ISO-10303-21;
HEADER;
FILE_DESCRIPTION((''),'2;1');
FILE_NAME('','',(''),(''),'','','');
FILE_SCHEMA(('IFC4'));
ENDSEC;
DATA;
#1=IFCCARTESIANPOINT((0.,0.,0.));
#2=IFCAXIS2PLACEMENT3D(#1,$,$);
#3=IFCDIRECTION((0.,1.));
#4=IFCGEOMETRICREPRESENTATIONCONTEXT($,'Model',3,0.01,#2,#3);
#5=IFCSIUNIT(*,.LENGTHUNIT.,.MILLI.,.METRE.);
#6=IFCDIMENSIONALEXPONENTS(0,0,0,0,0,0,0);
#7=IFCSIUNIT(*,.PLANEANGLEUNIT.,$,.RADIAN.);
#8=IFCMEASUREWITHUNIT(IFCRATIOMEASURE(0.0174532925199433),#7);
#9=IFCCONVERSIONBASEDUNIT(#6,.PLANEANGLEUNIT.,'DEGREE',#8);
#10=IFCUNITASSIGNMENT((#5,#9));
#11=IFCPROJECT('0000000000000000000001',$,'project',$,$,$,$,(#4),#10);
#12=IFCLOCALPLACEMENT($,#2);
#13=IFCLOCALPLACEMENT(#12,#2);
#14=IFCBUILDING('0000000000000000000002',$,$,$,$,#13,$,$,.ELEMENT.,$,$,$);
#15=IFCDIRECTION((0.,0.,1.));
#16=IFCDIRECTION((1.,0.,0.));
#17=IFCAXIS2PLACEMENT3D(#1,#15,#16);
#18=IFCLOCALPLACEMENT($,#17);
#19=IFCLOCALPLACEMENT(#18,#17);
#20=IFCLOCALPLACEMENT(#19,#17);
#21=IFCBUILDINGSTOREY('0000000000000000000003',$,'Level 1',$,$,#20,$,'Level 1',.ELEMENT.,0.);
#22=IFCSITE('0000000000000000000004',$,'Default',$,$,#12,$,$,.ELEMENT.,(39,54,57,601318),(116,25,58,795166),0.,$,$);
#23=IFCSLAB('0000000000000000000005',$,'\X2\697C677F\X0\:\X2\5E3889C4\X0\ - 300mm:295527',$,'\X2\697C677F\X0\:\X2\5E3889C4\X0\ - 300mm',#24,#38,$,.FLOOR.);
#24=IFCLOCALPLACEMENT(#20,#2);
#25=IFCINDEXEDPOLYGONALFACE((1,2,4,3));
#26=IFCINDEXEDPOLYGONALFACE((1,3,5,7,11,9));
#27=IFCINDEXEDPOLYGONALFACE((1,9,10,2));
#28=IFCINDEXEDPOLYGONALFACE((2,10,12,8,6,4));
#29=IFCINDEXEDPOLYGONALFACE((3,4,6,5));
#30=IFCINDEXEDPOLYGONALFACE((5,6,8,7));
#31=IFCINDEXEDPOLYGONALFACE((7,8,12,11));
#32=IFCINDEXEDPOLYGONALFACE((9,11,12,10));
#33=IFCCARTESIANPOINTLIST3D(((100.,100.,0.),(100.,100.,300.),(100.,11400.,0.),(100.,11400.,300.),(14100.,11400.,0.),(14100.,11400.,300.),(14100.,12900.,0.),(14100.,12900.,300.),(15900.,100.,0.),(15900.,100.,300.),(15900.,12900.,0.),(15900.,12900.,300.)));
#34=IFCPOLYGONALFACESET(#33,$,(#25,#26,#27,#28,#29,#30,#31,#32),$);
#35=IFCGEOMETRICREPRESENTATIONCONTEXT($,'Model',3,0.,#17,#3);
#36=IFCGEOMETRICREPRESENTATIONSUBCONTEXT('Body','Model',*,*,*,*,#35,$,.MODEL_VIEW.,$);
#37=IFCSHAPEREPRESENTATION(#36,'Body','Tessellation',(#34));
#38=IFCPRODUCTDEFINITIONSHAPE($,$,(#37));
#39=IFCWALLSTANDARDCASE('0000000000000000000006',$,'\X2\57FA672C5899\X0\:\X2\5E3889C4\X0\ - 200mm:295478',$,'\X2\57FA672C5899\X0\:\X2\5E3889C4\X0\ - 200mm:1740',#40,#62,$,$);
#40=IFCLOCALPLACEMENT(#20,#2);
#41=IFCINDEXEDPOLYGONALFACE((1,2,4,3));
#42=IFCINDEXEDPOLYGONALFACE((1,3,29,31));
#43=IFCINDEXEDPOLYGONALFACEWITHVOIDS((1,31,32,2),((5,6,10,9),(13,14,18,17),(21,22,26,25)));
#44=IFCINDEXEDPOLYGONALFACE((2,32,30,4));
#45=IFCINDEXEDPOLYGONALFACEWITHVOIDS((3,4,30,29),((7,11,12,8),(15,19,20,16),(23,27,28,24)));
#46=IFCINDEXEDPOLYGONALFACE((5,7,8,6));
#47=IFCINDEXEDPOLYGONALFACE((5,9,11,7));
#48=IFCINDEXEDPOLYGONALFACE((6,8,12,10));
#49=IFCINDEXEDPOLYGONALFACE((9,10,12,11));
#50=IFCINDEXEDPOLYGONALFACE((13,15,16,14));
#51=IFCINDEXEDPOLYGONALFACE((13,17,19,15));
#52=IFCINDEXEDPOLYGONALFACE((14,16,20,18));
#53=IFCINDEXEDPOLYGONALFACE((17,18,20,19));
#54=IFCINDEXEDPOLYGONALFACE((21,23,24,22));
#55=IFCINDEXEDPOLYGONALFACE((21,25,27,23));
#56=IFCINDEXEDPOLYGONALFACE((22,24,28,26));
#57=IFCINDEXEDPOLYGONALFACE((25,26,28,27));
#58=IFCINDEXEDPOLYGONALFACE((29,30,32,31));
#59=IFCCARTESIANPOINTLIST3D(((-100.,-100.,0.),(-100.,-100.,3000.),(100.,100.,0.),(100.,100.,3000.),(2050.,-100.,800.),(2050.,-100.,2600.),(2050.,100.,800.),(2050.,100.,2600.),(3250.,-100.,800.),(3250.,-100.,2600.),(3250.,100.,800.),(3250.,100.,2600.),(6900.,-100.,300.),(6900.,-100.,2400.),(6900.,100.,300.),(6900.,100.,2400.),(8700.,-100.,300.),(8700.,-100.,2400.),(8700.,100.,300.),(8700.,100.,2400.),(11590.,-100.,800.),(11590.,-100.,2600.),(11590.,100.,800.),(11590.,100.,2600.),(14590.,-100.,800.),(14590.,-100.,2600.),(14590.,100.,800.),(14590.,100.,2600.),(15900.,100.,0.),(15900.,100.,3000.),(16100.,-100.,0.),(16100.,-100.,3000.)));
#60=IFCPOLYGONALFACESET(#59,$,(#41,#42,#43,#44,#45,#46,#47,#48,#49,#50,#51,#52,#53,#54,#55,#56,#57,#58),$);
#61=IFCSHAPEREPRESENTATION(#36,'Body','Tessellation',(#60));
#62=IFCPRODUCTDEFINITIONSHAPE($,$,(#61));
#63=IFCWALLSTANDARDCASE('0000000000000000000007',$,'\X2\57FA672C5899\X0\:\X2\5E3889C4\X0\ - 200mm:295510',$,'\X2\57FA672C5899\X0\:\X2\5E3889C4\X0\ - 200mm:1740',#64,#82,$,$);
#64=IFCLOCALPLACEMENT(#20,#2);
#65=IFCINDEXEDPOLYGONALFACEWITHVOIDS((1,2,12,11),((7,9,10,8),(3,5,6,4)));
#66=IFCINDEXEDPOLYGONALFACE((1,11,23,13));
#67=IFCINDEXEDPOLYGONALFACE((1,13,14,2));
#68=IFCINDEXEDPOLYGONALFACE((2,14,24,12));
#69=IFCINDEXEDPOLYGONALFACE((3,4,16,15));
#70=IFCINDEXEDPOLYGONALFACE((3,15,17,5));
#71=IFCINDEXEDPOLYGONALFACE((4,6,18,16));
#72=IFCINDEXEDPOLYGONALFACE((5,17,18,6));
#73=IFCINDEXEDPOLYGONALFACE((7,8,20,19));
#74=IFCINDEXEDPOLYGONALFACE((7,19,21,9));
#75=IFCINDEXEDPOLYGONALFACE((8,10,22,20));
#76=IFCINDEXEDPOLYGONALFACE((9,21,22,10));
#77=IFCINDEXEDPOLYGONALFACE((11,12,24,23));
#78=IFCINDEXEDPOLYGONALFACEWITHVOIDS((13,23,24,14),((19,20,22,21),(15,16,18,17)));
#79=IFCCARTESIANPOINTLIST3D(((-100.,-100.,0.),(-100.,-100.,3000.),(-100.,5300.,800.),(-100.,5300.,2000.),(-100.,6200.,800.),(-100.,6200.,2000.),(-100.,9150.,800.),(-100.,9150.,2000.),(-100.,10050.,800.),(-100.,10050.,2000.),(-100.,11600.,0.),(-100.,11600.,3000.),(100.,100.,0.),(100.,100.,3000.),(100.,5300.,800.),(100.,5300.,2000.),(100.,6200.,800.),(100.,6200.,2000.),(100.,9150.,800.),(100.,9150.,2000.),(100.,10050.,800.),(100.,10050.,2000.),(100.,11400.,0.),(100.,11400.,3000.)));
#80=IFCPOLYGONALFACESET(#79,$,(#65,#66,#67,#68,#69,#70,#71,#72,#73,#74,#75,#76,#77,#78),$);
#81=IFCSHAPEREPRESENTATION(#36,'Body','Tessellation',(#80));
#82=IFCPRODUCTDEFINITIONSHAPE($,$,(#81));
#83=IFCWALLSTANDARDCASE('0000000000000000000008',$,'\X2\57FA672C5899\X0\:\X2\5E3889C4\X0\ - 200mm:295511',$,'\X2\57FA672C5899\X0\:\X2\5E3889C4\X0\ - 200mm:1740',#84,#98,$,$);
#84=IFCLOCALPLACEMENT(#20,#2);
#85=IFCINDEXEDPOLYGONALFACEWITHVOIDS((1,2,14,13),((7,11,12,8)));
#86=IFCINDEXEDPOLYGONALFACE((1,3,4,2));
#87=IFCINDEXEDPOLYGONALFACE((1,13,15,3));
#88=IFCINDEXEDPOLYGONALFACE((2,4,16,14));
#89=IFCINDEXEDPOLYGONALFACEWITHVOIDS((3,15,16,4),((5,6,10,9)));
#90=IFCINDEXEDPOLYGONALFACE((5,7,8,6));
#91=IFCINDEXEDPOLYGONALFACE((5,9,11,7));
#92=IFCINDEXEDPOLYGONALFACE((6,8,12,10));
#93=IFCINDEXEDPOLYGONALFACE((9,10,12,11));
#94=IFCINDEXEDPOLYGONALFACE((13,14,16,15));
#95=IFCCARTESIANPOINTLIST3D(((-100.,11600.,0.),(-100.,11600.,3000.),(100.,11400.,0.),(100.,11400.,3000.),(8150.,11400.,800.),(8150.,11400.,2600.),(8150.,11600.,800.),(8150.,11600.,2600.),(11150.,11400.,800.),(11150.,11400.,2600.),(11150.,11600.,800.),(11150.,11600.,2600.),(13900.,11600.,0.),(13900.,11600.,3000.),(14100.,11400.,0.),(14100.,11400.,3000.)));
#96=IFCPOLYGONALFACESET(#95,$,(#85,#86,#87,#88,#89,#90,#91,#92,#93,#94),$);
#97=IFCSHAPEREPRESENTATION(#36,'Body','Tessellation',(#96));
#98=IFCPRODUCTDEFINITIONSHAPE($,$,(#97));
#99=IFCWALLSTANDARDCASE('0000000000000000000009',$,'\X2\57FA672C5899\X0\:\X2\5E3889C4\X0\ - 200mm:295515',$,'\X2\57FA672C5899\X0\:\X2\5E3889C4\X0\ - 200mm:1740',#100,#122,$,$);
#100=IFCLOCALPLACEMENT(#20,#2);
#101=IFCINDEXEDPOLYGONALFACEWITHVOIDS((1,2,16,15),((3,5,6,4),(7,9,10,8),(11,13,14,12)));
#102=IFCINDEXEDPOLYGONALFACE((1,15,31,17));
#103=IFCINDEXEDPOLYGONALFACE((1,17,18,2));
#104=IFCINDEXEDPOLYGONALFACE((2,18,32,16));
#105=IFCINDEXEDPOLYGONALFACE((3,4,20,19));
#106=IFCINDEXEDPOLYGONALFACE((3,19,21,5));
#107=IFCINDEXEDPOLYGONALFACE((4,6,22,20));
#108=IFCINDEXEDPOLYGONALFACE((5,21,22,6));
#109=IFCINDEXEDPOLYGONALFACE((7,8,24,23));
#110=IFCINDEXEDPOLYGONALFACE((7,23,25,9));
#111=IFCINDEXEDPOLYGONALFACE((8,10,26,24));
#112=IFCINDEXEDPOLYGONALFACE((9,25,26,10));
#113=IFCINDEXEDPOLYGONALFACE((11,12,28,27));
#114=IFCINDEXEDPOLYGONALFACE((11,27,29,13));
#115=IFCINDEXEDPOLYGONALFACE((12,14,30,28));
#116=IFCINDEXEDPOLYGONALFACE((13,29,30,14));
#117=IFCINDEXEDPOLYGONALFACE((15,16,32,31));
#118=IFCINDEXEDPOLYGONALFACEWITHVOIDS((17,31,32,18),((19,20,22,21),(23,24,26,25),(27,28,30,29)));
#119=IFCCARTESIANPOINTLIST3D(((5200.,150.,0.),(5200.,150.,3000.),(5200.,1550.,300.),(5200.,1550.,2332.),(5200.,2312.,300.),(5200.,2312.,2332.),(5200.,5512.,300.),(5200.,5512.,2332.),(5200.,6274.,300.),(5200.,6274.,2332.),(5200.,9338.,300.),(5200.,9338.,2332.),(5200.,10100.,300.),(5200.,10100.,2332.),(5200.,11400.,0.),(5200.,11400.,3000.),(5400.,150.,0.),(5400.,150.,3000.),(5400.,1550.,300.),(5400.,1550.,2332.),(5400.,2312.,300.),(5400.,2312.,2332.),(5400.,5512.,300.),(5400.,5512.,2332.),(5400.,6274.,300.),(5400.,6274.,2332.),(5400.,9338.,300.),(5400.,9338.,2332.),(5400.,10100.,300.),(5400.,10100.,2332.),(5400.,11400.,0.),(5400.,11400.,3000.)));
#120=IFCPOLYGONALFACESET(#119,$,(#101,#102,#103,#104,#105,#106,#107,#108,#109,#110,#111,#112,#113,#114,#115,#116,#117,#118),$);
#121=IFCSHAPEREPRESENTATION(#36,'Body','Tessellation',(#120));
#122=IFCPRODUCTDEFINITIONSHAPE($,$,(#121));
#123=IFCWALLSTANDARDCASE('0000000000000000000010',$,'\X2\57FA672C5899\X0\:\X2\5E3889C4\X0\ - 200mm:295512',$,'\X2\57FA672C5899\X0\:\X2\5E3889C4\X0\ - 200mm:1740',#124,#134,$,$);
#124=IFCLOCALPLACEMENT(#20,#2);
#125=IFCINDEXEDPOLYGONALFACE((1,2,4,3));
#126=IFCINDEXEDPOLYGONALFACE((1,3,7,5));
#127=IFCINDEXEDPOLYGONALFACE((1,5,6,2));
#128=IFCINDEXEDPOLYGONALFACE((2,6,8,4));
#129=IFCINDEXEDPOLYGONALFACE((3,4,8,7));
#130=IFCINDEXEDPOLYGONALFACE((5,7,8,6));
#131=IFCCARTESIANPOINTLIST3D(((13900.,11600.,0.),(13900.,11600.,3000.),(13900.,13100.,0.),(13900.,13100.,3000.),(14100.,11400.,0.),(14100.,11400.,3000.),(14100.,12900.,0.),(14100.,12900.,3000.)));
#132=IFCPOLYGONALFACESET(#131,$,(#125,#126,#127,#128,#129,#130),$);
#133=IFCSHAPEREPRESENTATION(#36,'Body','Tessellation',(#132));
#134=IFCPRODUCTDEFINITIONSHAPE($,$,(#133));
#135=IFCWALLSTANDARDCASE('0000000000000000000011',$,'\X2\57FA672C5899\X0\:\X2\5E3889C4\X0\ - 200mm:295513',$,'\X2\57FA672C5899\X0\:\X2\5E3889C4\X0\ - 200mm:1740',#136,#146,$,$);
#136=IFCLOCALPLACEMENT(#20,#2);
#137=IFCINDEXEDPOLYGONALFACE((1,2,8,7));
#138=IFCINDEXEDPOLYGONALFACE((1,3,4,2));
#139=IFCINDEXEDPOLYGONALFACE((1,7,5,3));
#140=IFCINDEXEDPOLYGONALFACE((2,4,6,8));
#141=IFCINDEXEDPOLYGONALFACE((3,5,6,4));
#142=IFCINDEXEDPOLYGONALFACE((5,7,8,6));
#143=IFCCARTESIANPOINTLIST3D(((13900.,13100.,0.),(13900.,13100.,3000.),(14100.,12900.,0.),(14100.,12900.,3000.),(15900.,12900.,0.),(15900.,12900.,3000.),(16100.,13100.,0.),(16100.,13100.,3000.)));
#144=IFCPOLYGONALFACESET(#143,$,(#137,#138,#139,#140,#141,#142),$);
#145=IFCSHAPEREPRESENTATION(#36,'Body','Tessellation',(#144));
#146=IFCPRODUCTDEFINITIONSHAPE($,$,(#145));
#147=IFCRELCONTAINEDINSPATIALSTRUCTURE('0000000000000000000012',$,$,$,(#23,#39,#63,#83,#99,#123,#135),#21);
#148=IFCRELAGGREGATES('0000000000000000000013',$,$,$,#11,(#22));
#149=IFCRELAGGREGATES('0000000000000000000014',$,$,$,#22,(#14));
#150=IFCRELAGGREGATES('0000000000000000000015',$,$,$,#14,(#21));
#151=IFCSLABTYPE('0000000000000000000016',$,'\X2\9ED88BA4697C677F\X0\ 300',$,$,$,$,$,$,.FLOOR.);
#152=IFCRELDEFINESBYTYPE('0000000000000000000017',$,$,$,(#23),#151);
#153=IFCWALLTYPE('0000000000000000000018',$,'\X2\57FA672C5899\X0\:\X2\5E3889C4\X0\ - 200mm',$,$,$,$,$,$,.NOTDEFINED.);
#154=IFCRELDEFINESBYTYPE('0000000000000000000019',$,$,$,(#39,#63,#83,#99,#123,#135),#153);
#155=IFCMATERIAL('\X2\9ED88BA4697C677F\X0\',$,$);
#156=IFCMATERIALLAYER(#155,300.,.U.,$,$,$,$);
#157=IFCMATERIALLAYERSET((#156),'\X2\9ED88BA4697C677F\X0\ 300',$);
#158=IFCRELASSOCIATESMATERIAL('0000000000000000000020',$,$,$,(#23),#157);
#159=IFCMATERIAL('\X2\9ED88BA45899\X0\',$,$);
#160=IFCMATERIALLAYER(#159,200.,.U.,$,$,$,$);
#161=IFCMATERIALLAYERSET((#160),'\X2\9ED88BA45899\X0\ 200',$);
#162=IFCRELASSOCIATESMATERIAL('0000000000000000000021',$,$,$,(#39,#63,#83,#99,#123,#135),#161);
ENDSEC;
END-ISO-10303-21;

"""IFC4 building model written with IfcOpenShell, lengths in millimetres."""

from ifc_helpers import new_model, entity, si_unit, converted_unit, direction, frame, origin, origin_with_axes, place, context, subcontext, project, spatial, polyline, outline, extrude, material, layer, layer_set, layer_usage, type_object, element, save


model = new_model("IFC4")

# Units and contexts
model_context_1 = context("Model", 3, precision=0.01, world=origin(), true_north=direction((0.0, 1.0)))
model_context_2 = context("Model", 3, precision=0.0, world=origin_with_axes(), true_north=direction((0.0, 1.0)))
body_context = subcontext(model_context_2, "Body", "Model", "MODEL_VIEW")
ifc_project = project(units=[si_unit("LENGTHUNIT", "METRE", prefix="MILLI"), converted_unit("PLANEANGLEUNIT", "DEGREE", entity("IfcRatioMeasure", 0.0174532925199433), si_unit("PLANEANGLEUNIT", "RADIAN"), dimensions=[0, 0, 0, 0, 0, 0, 0])], contexts=[model_context_1])

# Site, building, storey
site_placement = place(None, origin())
site = spatial("IfcSite", under=ifc_project, at=site_placement, Name="Default", CompositionType="ELEMENT", RefLatitude=(39, 54, 57, 601318), RefLongitude=(116, 25, 58, 795166), RefElevation=0.0)
building_placement = place(site_placement, origin())
building = spatial("IfcBuilding", under=site, at=building_placement, CompositionType="ELEMENT")
placement_1 = place(None, origin_with_axes())
placement_2 = place(placement_1, origin_with_axes())
storey_placement = place(placement_2, origin_with_axes())
storey = spatial("IfcBuildingStorey", under=building, at=storey_placement, Name="Level 1", LongName="Level 1", CompositionType="ELEMENT", Elevation=0.0)

# Slab
ifc_material_1 = material(Name="默认楼板")
ifc_layer_1 = layer(ifc_material_1, 300.0, ventilated="UNKNOWN")
ifc_layer_set_1 = layer_set([ifc_layer_1], Name="默认楼板 300")
ifc_layer_usage_1 = layer_usage(ifc_layer_set_1, "AXIS3", "NEGATIVE", 300.0)
slab_type = type_object("IfcSlabType", Name="默认楼板 300", PredefinedType="FLOOR")
slab_placement = place(storey_placement, frame((100.0, 100.0, 0.0), z_axis=(0.0, 0.0, 1.0), x_axis=(1.0, 0.0, 0.0)))
element("IfcSlab", 1, at=slab_placement, inside=storey, type_object=slab_type, material=ifc_layer_usage_1, Name="楼板:常规 - 300mm:295527", ObjectType="楼板:常规 - 300mm", PredefinedType="FLOOR", context=body_context, shape_type="SweptSolid", body=[
    extrude(outline(polyline([(0.0, 0.0), (15800.0, 0.0), (15800.0, 12800.0), (14000.0, 12800.0), (14000.0, 11300.0), (0.0, 11300.0), (0.0, 0.0)])), origin_with_axes(), (0.0, 0.0, 1.0), 300.0),
])

# Walls, openings
ifc_material_2 = material(Name="默认墙")
ifc_layer_2 = layer(ifc_material_2, 200.0, ventilated="UNKNOWN")
ifc_layer_set_2 = layer_set([ifc_layer_2], Name="默认墙 200")
ifc_layer_usage_2 = layer_usage(ifc_layer_set_2, "AXIS2", "POSITIVE", -100.0)
wall_type = type_object("IfcWallType", Name="基本墙:常规 - 200mm", PredefinedType="NOTDEFINED")
wall_1_placement = place(storey_placement, frame((16000.0, 0.0, 0.0), z_axis=(0.0, 0.0, 1.0), x_axis=(-1.0, 0.0, 0.0)))
wall_1 = element("IfcWallStandardCase", 2, at=wall_1_placement, inside=storey, type_object=wall_type, material=ifc_layer_usage_2, Name="基本墙:常规 - 200mm:295478", ObjectType="基本墙:常规 - 200mm:1740", context=body_context, shape_type="SweptSolid", body=[
    extrude(outline(polyline([(100.0, -100.0), (15900.0, -100.0), (16100.0, 100.0), (-100.0, 100.0), (100.0, -100.0)])), origin_with_axes(), (0.0, 0.0, 1.0), 3000.0),
])
opening_1_placement = place(wall_1_placement, frame((13350.0, 0.0, 800.0), z_axis=(0.0, 0.0, 1.0), x_axis=(1.0, 0.0, 0.0)))
element("IfcOpeningElement", 3, at=opening_1_placement, cuts=wall_1, context=body_context, shape_type="SweptSolid", body=[
    extrude(outline(polyline([(-600.0, 0.0), (-600.0, -1800.0), (600.0, -1800.0), (600.0, 0.0), (-600.0, 0.0)])), frame((0.0, -100.0, 0.0), z_axis=(0.0, 1.0, 0.0), x_axis=(1.0, 0.0, 0.0)), (0.0, 0.0, 1.0), 200.0),
])
opening_2_placement = place(wall_1_placement, frame((2910.0, 0.0, 800.0), z_axis=(0.0, 0.0, 1.0), x_axis=(1.0, 0.0, 0.0)))
element("IfcOpeningElement", 4, at=opening_2_placement, cuts=wall_1, context=body_context, shape_type="SweptSolid", body=[
    extrude(outline(polyline([(-1500.0, 0.0), (-1500.0, -1800.0), (1500.0, -1800.0), (1500.0, 0.0), (-1500.0, 0.0)])), frame((0.0, -100.0, 0.0), z_axis=(0.0, 1.0, 0.0), x_axis=(1.0, 0.0, 0.0)), (0.0, 0.0, 1.0), 200.0),
])
opening_3_placement = place(wall_1_placement, frame((8200.0, 0.0, 300.0), z_axis=(0.0, 0.0, 1.0), x_axis=(1.0, 0.0, 0.0)))
element("IfcOpeningElement", 5, at=opening_3_placement, cuts=wall_1, context=body_context, shape_type="SweptSolid", body=[
    extrude(outline(polyline([(-900.0, 0.0), (-900.0, -2100.0), (900.0, -2100.0), (900.0, 0.0), (-900.0, 0.0)])), frame((0.0, -100.0, 0.0), z_axis=(0.0, 1.0, 0.0), x_axis=(1.0, 0.0, 0.0)), (0.0, 0.0, 1.0), 200.0),
])
ifc_layer_usage_3 = layer_usage(ifc_layer_set_2, "AXIS2", "POSITIVE", -100.0)
wall_2_placement = place(storey_placement, frame((0.0, 0.0, 0.0), z_axis=(0.0, 0.0, 1.0), x_axis=(0.0, 1.0, 0.0)))
wall_2 = element("IfcWallStandardCase", 6, at=wall_2_placement, inside=storey, type_object=wall_type, material=ifc_layer_usage_3, Name="基本墙:常规 - 200mm:295510", ObjectType="基本墙:常规 - 200mm:1740", context=body_context, shape_type="SweptSolid", body=[
    extrude(outline(polyline([(100.0, -100.0), (11400.0, -100.0), (11600.0, 100.0), (-100.0, 100.0), (100.0, -100.0)])), origin_with_axes(), (0.0, 0.0, 1.0), 3000.0),
])
opening_4_placement = place(wall_2_placement, frame((5750.0, 0.0, 800.0), z_axis=(0.0, 0.0, 1.0), x_axis=(1.0, 0.0, 0.0)))
element("IfcOpeningElement", 7, at=opening_4_placement, cuts=wall_2, context=body_context, shape_type="SweptSolid", body=[
    extrude(outline(polyline([(450.0, -1200.0), (450.0, 0.0), (-450.0, 0.0), (-450.0, -1200.0), (450.0, -1200.0)])), frame((0.0, 100.0, 0.0), z_axis=(0.0, -1.0, 0.0), x_axis=(-1.0, 0.0, 0.0)), (0.0, 0.0, 1.0), 200.0),
])
opening_5_placement = place(wall_2_placement, frame((9600.0, 0.0, 800.0), z_axis=(0.0, 0.0, 1.0), x_axis=(1.0, 0.0, 0.0)))
element("IfcOpeningElement", 8, at=opening_5_placement, cuts=wall_2, context=body_context, shape_type="SweptSolid", body=[
    extrude(outline(polyline([(450.0, -1200.0), (450.0, 0.0), (-450.0, 0.0), (-450.0, -1200.0), (450.0, -1200.0)])), frame((0.0, 100.0, 0.0), z_axis=(0.0, -1.0, 0.0), x_axis=(-1.0, 0.0, 0.0)), (0.0, 0.0, 1.0), 200.0),
])

# Wall, opening
ifc_layer_usage_4 = layer_usage(ifc_layer_set_2, "AXIS2", "POSITIVE", -100.0)
wall_3_placement = place(storey_placement, frame((0.0, 11500.0, 0.0), z_axis=(0.0, 0.0, 1.0), x_axis=(1.0, 0.0, 0.0)))
wall_3 = element("IfcWallStandardCase", 9, at=wall_3_placement, inside=storey, type_object=wall_type, material=ifc_layer_usage_4, Name="基本墙:常规 - 200mm:295511", ObjectType="基本墙:常规 - 200mm:1740", context=body_context, shape_type="SweptSolid", body=[
    extrude(outline(polyline([(100.0, -100.0), (14100.0, -100.0), (13900.0, 100.0), (-100.0, 100.0), (100.0, -100.0)])), origin_with_axes(), (0.0, 0.0, 1.0), 3000.0),
])
opening_6_placement = place(wall_3_placement, frame((9650.0, 0.0, 800.0), z_axis=(0.0, 0.0, 1.0), x_axis=(1.0, 0.0, 0.0)))
element("IfcOpeningElement", 10, at=opening_6_placement, cuts=wall_3, context=body_context, shape_type="SweptSolid", body=[
    extrude(outline(polyline([(-1500.0, 0.0), (-1500.0, -1800.0), (1500.0, -1800.0), (1500.0, 0.0), (-1500.0, 0.0)])), frame((0.0, -100.0, 0.0), z_axis=(0.0, 1.0, 0.0), x_axis=(1.0, 0.0, 0.0)), (0.0, 0.0, 1.0), 200.0),
])

# Wall, openings
ifc_layer_usage_5 = layer_usage(ifc_layer_set_2, "AXIS2", "POSITIVE", -100.0)
wall_4_placement = place(storey_placement, frame((5300.0, 11500.0, 0.0), z_axis=(0.0, 0.0, 1.0), x_axis=(0.0, -1.0, 0.0)))
wall_4 = element("IfcWallStandardCase", 11, at=wall_4_placement, inside=storey, type_object=wall_type, material=ifc_layer_usage_5, Name="基本墙:常规 - 200mm:295515", ObjectType="基本墙:常规 - 200mm:1740", context=body_context, shape_type="SweptSolid", body=[
    extrude(outline(polyline([(100.0, -100.0), (11350.0, -100.0), (11350.0, 100.0), (100.0, 100.0), (100.0, -100.0)])), origin_with_axes(), (0.0, 0.0, 1.0), 3000.0),
])
opening_7_placement = place(wall_4_placement, frame((1781.0, 0.0, 300.0), z_axis=(0.0, 0.0, 1.0), x_axis=(1.0, 0.0, 0.0)))
element("IfcOpeningElement", 12, at=opening_7_placement, cuts=wall_4, context=body_context, shape_type="SweptSolid", body=[
    extrude(outline(polyline([(-381.0, -2032.0), (381.0, -2032.0), (381.0, 0.0), (-381.0, 0.0), (-381.0, -2032.0)])), frame((0.0, -100.0, 0.0), z_axis=(0.0, 1.0, 0.0), x_axis=(1.0, 0.0, 0.0)), (0.0, 0.0, 1.0), 200.0),
])
opening_8_placement = place(wall_4_placement, frame((9569.0, 0.0, 300.0), z_axis=(0.0, 0.0, 1.0), x_axis=(1.0, 0.0, 0.0)))
element("IfcOpeningElement", 13, at=opening_8_placement, cuts=wall_4, context=body_context, shape_type="SweptSolid", body=[
    extrude(outline(polyline([(-381.0, -2032.0), (381.0, -2032.0), (381.0, 0.0), (-381.0, 0.0), (-381.0, -2032.0)])), frame((0.0, -100.0, 0.0), z_axis=(0.0, 1.0, 0.0), x_axis=(1.0, 0.0, 0.0)), (0.0, 0.0, 1.0), 200.0),
])
opening_9_placement = place(wall_4_placement, frame((5607.0, 0.0, 300.0), z_axis=(0.0, 0.0, 1.0), x_axis=(1.0, 0.0, 0.0)))
element("IfcOpeningElement", 14, at=opening_9_placement, cuts=wall_4, context=body_context, shape_type="SweptSolid", body=[
    extrude(outline(polyline([(-381.0, -2032.0), (381.0, -2032.0), (381.0, 0.0), (-381.0, 0.0), (-381.0, -2032.0)])), frame((0.0, -100.0, 0.0), z_axis=(0.0, 1.0, 0.0), x_axis=(1.0, 0.0, 0.0)), (0.0, 0.0, 1.0), 200.0),
])

# Walls
ifc_layer_usage_6 = layer_usage(ifc_layer_set_2, "AXIS2", "POSITIVE", -100.0)
wall_5_placement = place(storey_placement, frame((14000.0, 11500.0, 0.0), z_axis=(0.0, 0.0, 1.0), x_axis=(0.0, 1.0, 0.0)))
element("IfcWallStandardCase", 15, at=wall_5_placement, inside=storey, type_object=wall_type, material=ifc_layer_usage_6, Name="基本墙:常规 - 200mm:295512", ObjectType="基本墙:常规 - 200mm:1740", context=body_context, shape_type="SweptSolid", body=[
    extrude(outline(polyline([(-100.0, -100.0), (1400.0, -100.0), (1600.0, 100.0), (100.0, 100.0), (-100.0, -100.0)])), origin_with_axes(), (0.0, 0.0, 1.0), 3000.0),
])
ifc_layer_usage_7 = layer_usage(ifc_layer_set_2, "AXIS2", "POSITIVE", -100.0)
wall_6_placement = place(storey_placement, frame((14000.0, 13000.0, 0.0), z_axis=(0.0, 0.0, 1.0), x_axis=(1.0, 0.0, 0.0)))
element("IfcWallStandardCase", 16, at=wall_6_placement, inside=storey, type_object=wall_type, material=ifc_layer_usage_7, Name="基本墙:常规 - 200mm:295513", ObjectType="基本墙:常规 - 200mm:1740", context=body_context, shape_type="SweptSolid", body=[
    extrude(outline(polyline([(100.0, -100.0), (1900.0, -100.0), (2100.0, 100.0), (-100.0, 100.0), (100.0, -100.0)])), origin_with_axes(), (0.0, 0.0, 1.0), 3000.0),
])

save(model, "model.ifc")
